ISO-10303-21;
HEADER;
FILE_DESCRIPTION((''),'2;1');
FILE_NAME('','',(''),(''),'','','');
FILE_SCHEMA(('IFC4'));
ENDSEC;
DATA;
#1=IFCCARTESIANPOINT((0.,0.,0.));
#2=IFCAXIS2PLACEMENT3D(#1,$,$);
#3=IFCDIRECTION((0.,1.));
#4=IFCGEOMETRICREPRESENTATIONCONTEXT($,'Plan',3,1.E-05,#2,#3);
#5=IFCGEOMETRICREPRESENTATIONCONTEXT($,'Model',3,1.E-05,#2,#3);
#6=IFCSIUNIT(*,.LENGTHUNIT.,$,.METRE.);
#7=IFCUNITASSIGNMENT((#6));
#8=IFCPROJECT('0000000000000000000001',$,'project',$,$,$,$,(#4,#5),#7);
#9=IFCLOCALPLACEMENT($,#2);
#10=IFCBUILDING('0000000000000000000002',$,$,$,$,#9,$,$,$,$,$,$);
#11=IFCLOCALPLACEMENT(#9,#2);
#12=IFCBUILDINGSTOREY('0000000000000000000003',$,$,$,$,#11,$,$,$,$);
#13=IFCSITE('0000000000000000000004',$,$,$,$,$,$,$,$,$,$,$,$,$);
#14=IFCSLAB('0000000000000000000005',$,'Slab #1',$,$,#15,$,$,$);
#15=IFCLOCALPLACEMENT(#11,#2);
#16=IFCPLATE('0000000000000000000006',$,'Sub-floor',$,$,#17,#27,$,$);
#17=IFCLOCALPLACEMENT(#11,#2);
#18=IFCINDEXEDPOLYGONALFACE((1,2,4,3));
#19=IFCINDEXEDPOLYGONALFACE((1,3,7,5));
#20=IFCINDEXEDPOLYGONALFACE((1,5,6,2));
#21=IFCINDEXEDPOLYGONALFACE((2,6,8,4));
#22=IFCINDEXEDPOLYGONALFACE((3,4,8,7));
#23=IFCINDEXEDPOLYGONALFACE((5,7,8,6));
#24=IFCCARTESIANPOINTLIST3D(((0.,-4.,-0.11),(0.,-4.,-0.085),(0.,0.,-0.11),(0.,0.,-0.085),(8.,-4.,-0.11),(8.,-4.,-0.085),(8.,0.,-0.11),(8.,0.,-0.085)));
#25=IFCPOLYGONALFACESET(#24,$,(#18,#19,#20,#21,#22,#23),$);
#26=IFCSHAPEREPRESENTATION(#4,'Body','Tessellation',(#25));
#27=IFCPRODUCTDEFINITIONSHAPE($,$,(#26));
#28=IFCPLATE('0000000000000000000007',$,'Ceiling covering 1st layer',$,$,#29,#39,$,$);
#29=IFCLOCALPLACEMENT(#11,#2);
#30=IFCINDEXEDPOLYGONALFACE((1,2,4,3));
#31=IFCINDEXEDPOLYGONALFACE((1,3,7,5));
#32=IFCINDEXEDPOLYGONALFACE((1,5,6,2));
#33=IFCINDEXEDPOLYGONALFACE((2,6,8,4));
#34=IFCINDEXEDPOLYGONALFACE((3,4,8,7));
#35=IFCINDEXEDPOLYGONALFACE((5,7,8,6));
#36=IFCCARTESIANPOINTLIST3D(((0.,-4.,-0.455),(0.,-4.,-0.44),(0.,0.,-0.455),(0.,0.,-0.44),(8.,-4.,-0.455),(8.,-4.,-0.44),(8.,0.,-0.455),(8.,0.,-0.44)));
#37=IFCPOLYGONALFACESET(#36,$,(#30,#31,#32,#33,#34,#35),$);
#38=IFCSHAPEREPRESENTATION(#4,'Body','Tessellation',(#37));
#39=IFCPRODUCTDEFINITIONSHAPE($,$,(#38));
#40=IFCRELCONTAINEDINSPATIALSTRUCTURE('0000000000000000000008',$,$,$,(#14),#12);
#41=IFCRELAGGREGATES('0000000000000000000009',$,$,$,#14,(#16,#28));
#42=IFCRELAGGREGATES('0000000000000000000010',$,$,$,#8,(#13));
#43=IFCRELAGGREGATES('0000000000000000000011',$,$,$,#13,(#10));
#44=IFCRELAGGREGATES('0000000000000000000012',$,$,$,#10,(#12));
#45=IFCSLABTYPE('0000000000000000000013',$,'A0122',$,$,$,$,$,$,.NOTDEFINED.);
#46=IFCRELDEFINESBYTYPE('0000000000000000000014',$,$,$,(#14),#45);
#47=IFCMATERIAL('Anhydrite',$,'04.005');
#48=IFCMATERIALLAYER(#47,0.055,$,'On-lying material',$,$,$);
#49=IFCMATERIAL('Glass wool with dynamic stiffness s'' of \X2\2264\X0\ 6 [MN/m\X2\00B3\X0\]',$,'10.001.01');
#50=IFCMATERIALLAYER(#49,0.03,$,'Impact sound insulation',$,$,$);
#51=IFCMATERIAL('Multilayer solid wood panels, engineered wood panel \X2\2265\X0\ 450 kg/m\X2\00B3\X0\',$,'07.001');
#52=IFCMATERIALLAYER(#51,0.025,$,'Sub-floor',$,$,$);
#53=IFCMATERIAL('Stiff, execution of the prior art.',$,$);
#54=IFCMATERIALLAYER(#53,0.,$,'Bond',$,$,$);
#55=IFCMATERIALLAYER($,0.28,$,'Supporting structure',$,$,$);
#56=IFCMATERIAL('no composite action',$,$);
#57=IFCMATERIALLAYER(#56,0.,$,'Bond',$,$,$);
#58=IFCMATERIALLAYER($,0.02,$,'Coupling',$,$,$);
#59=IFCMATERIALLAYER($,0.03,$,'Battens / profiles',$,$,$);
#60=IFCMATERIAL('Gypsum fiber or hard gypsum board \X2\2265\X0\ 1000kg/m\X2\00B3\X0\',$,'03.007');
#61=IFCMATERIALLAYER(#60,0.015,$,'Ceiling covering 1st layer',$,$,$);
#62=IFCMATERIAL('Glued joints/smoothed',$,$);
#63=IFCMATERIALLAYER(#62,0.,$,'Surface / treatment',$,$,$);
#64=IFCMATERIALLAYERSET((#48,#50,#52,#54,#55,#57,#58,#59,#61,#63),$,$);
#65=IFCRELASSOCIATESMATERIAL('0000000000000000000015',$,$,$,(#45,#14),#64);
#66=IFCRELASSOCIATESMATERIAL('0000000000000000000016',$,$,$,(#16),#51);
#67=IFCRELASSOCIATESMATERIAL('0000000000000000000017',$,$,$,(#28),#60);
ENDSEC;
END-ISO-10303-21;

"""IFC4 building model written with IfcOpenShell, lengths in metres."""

from ifc_helpers import new_model, si_unit, direction, frame, frame_2d, origin, place, context, project, spatial, rectangle, extrude, material, layer, layer_set, type_object, element, aggregate, save


model = new_model("IFC4")

# Units and contexts
plan_context = context("Plan", 3, precision=1e-05, world=origin(), true_north=direction((0.0, 1.0)))
model_context = context("Model", 3, precision=1e-05, world=origin(), true_north=direction((0.0, 1.0)))
ifc_project = project(units=[si_unit("LENGTHUNIT", "METRE")], contexts=[plan_context, model_context])

# Site, building, storey
site = spatial("IfcSite", under=ifc_project)
building_placement = place(None, origin())
building = spatial("IfcBuilding", under=site, at=building_placement)
storey_placement = place(building_placement, origin())
storey = spatial("IfcBuildingStorey", under=building, at=storey_placement)

# Slab, plates
ifc_material_1 = material(Name="Anhydrite", Category="04.005")
ifc_layer_1 = layer(ifc_material_1, 0.055, Name="On-lying material")
ifc_material_2 = material(Name="Glass wool with dynamic stiffness s' of ≤ 6 [MN/m³]", Category="10.001.01")
ifc_layer_2 = layer(ifc_material_2, 0.03, Name="Impact sound insulation")
ifc_material_3 = material(Name="Multilayer solid wood panels, engineered wood panel ≥ 450 kg/m³", Category="07.001")
ifc_layer_3 = layer(ifc_material_3, 0.025, Name="Sub-floor")
ifc_material_4 = material(Name="Stiff, execution of the prior art.")
ifc_layer_4 = layer(ifc_material_4, 0.0, Name="Bond")
ifc_layer_5 = layer(None, 0.28, Name="Supporting structure")
ifc_material_5 = material(Name="no composite action")
ifc_layer_6 = layer(ifc_material_5, 0.0, Name="Bond")
ifc_layer_7 = layer(None, 0.02, Name="Coupling")
ifc_layer_8 = layer(None, 0.03, Name="Battens / profiles")
ifc_material_6 = material(Name="Gypsum fiber or hard gypsum board ≥ 1000kg/m³", Category="03.007")
ifc_layer_9 = layer(ifc_material_6, 0.015, Name="Ceiling covering 1st layer")
ifc_material_7 = material(Name="Glued joints/smoothed")
ifc_layer_10 = layer(ifc_material_7, 0.0, Name="Surface / treatment")
ifc_layer_set = layer_set([ifc_layer_1, ifc_layer_2, ifc_layer_3, ifc_layer_4, ifc_layer_5, ifc_layer_6, ifc_layer_7, ifc_layer_8, ifc_layer_9, ifc_layer_10])
slab_type = type_object("IfcSlabType", Name="A0122", PredefinedType="NOTDEFINED", material=ifc_layer_set)
slab_placement = place(None, frame((0.0, 0.0, 0.0), z_axis=(0.0, 0.0, -1.0), x_axis=(1.0, 0.0, 0.0)))
slab = element("IfcSlab", 1, at=slab_placement, inside=storey, type_object=slab_type, material=ifc_layer_set, Name="Slab #1")
plate_1_placement = place(slab_placement, origin())
plate_1 = element("IfcPlate", 2, at=plate_1_placement, material=ifc_material_3, Name="Sub-floor", context=plan_context, shape_type="SweptSolid", body=[
    extrude(rectangle(XDim=8.0, YDim=4.0, at=frame_2d((4.0, 2.0), x_axis=(1.0, 0.0))), frame((0.0, 0.0, 0.085), z_axis=(0.0, 0.0, 1.0), x_axis=(1.0, 0.0, 0.0)), (0.0, 0.0, 1.0), 0.025),
])
plate_2_placement = place(slab_placement, origin())
plate_2 = element("IfcPlate", 3, at=plate_2_placement, material=ifc_material_6, Name="Ceiling covering 1st layer", context=plan_context, shape_type="SweptSolid", body=[
    extrude(rectangle(XDim=8.0, YDim=4.0, at=frame_2d((4.0, 2.0), x_axis=(1.0, 0.0))), frame((0.0, 0.0, 0.44), z_axis=(0.0, 0.0, 1.0), x_axis=(1.0, 0.0, 0.0)), (0.0, 0.0, 1.0), 0.015),
])
aggregate(slab, [plate_1, plate_2])

save(model, "model.ifc")
